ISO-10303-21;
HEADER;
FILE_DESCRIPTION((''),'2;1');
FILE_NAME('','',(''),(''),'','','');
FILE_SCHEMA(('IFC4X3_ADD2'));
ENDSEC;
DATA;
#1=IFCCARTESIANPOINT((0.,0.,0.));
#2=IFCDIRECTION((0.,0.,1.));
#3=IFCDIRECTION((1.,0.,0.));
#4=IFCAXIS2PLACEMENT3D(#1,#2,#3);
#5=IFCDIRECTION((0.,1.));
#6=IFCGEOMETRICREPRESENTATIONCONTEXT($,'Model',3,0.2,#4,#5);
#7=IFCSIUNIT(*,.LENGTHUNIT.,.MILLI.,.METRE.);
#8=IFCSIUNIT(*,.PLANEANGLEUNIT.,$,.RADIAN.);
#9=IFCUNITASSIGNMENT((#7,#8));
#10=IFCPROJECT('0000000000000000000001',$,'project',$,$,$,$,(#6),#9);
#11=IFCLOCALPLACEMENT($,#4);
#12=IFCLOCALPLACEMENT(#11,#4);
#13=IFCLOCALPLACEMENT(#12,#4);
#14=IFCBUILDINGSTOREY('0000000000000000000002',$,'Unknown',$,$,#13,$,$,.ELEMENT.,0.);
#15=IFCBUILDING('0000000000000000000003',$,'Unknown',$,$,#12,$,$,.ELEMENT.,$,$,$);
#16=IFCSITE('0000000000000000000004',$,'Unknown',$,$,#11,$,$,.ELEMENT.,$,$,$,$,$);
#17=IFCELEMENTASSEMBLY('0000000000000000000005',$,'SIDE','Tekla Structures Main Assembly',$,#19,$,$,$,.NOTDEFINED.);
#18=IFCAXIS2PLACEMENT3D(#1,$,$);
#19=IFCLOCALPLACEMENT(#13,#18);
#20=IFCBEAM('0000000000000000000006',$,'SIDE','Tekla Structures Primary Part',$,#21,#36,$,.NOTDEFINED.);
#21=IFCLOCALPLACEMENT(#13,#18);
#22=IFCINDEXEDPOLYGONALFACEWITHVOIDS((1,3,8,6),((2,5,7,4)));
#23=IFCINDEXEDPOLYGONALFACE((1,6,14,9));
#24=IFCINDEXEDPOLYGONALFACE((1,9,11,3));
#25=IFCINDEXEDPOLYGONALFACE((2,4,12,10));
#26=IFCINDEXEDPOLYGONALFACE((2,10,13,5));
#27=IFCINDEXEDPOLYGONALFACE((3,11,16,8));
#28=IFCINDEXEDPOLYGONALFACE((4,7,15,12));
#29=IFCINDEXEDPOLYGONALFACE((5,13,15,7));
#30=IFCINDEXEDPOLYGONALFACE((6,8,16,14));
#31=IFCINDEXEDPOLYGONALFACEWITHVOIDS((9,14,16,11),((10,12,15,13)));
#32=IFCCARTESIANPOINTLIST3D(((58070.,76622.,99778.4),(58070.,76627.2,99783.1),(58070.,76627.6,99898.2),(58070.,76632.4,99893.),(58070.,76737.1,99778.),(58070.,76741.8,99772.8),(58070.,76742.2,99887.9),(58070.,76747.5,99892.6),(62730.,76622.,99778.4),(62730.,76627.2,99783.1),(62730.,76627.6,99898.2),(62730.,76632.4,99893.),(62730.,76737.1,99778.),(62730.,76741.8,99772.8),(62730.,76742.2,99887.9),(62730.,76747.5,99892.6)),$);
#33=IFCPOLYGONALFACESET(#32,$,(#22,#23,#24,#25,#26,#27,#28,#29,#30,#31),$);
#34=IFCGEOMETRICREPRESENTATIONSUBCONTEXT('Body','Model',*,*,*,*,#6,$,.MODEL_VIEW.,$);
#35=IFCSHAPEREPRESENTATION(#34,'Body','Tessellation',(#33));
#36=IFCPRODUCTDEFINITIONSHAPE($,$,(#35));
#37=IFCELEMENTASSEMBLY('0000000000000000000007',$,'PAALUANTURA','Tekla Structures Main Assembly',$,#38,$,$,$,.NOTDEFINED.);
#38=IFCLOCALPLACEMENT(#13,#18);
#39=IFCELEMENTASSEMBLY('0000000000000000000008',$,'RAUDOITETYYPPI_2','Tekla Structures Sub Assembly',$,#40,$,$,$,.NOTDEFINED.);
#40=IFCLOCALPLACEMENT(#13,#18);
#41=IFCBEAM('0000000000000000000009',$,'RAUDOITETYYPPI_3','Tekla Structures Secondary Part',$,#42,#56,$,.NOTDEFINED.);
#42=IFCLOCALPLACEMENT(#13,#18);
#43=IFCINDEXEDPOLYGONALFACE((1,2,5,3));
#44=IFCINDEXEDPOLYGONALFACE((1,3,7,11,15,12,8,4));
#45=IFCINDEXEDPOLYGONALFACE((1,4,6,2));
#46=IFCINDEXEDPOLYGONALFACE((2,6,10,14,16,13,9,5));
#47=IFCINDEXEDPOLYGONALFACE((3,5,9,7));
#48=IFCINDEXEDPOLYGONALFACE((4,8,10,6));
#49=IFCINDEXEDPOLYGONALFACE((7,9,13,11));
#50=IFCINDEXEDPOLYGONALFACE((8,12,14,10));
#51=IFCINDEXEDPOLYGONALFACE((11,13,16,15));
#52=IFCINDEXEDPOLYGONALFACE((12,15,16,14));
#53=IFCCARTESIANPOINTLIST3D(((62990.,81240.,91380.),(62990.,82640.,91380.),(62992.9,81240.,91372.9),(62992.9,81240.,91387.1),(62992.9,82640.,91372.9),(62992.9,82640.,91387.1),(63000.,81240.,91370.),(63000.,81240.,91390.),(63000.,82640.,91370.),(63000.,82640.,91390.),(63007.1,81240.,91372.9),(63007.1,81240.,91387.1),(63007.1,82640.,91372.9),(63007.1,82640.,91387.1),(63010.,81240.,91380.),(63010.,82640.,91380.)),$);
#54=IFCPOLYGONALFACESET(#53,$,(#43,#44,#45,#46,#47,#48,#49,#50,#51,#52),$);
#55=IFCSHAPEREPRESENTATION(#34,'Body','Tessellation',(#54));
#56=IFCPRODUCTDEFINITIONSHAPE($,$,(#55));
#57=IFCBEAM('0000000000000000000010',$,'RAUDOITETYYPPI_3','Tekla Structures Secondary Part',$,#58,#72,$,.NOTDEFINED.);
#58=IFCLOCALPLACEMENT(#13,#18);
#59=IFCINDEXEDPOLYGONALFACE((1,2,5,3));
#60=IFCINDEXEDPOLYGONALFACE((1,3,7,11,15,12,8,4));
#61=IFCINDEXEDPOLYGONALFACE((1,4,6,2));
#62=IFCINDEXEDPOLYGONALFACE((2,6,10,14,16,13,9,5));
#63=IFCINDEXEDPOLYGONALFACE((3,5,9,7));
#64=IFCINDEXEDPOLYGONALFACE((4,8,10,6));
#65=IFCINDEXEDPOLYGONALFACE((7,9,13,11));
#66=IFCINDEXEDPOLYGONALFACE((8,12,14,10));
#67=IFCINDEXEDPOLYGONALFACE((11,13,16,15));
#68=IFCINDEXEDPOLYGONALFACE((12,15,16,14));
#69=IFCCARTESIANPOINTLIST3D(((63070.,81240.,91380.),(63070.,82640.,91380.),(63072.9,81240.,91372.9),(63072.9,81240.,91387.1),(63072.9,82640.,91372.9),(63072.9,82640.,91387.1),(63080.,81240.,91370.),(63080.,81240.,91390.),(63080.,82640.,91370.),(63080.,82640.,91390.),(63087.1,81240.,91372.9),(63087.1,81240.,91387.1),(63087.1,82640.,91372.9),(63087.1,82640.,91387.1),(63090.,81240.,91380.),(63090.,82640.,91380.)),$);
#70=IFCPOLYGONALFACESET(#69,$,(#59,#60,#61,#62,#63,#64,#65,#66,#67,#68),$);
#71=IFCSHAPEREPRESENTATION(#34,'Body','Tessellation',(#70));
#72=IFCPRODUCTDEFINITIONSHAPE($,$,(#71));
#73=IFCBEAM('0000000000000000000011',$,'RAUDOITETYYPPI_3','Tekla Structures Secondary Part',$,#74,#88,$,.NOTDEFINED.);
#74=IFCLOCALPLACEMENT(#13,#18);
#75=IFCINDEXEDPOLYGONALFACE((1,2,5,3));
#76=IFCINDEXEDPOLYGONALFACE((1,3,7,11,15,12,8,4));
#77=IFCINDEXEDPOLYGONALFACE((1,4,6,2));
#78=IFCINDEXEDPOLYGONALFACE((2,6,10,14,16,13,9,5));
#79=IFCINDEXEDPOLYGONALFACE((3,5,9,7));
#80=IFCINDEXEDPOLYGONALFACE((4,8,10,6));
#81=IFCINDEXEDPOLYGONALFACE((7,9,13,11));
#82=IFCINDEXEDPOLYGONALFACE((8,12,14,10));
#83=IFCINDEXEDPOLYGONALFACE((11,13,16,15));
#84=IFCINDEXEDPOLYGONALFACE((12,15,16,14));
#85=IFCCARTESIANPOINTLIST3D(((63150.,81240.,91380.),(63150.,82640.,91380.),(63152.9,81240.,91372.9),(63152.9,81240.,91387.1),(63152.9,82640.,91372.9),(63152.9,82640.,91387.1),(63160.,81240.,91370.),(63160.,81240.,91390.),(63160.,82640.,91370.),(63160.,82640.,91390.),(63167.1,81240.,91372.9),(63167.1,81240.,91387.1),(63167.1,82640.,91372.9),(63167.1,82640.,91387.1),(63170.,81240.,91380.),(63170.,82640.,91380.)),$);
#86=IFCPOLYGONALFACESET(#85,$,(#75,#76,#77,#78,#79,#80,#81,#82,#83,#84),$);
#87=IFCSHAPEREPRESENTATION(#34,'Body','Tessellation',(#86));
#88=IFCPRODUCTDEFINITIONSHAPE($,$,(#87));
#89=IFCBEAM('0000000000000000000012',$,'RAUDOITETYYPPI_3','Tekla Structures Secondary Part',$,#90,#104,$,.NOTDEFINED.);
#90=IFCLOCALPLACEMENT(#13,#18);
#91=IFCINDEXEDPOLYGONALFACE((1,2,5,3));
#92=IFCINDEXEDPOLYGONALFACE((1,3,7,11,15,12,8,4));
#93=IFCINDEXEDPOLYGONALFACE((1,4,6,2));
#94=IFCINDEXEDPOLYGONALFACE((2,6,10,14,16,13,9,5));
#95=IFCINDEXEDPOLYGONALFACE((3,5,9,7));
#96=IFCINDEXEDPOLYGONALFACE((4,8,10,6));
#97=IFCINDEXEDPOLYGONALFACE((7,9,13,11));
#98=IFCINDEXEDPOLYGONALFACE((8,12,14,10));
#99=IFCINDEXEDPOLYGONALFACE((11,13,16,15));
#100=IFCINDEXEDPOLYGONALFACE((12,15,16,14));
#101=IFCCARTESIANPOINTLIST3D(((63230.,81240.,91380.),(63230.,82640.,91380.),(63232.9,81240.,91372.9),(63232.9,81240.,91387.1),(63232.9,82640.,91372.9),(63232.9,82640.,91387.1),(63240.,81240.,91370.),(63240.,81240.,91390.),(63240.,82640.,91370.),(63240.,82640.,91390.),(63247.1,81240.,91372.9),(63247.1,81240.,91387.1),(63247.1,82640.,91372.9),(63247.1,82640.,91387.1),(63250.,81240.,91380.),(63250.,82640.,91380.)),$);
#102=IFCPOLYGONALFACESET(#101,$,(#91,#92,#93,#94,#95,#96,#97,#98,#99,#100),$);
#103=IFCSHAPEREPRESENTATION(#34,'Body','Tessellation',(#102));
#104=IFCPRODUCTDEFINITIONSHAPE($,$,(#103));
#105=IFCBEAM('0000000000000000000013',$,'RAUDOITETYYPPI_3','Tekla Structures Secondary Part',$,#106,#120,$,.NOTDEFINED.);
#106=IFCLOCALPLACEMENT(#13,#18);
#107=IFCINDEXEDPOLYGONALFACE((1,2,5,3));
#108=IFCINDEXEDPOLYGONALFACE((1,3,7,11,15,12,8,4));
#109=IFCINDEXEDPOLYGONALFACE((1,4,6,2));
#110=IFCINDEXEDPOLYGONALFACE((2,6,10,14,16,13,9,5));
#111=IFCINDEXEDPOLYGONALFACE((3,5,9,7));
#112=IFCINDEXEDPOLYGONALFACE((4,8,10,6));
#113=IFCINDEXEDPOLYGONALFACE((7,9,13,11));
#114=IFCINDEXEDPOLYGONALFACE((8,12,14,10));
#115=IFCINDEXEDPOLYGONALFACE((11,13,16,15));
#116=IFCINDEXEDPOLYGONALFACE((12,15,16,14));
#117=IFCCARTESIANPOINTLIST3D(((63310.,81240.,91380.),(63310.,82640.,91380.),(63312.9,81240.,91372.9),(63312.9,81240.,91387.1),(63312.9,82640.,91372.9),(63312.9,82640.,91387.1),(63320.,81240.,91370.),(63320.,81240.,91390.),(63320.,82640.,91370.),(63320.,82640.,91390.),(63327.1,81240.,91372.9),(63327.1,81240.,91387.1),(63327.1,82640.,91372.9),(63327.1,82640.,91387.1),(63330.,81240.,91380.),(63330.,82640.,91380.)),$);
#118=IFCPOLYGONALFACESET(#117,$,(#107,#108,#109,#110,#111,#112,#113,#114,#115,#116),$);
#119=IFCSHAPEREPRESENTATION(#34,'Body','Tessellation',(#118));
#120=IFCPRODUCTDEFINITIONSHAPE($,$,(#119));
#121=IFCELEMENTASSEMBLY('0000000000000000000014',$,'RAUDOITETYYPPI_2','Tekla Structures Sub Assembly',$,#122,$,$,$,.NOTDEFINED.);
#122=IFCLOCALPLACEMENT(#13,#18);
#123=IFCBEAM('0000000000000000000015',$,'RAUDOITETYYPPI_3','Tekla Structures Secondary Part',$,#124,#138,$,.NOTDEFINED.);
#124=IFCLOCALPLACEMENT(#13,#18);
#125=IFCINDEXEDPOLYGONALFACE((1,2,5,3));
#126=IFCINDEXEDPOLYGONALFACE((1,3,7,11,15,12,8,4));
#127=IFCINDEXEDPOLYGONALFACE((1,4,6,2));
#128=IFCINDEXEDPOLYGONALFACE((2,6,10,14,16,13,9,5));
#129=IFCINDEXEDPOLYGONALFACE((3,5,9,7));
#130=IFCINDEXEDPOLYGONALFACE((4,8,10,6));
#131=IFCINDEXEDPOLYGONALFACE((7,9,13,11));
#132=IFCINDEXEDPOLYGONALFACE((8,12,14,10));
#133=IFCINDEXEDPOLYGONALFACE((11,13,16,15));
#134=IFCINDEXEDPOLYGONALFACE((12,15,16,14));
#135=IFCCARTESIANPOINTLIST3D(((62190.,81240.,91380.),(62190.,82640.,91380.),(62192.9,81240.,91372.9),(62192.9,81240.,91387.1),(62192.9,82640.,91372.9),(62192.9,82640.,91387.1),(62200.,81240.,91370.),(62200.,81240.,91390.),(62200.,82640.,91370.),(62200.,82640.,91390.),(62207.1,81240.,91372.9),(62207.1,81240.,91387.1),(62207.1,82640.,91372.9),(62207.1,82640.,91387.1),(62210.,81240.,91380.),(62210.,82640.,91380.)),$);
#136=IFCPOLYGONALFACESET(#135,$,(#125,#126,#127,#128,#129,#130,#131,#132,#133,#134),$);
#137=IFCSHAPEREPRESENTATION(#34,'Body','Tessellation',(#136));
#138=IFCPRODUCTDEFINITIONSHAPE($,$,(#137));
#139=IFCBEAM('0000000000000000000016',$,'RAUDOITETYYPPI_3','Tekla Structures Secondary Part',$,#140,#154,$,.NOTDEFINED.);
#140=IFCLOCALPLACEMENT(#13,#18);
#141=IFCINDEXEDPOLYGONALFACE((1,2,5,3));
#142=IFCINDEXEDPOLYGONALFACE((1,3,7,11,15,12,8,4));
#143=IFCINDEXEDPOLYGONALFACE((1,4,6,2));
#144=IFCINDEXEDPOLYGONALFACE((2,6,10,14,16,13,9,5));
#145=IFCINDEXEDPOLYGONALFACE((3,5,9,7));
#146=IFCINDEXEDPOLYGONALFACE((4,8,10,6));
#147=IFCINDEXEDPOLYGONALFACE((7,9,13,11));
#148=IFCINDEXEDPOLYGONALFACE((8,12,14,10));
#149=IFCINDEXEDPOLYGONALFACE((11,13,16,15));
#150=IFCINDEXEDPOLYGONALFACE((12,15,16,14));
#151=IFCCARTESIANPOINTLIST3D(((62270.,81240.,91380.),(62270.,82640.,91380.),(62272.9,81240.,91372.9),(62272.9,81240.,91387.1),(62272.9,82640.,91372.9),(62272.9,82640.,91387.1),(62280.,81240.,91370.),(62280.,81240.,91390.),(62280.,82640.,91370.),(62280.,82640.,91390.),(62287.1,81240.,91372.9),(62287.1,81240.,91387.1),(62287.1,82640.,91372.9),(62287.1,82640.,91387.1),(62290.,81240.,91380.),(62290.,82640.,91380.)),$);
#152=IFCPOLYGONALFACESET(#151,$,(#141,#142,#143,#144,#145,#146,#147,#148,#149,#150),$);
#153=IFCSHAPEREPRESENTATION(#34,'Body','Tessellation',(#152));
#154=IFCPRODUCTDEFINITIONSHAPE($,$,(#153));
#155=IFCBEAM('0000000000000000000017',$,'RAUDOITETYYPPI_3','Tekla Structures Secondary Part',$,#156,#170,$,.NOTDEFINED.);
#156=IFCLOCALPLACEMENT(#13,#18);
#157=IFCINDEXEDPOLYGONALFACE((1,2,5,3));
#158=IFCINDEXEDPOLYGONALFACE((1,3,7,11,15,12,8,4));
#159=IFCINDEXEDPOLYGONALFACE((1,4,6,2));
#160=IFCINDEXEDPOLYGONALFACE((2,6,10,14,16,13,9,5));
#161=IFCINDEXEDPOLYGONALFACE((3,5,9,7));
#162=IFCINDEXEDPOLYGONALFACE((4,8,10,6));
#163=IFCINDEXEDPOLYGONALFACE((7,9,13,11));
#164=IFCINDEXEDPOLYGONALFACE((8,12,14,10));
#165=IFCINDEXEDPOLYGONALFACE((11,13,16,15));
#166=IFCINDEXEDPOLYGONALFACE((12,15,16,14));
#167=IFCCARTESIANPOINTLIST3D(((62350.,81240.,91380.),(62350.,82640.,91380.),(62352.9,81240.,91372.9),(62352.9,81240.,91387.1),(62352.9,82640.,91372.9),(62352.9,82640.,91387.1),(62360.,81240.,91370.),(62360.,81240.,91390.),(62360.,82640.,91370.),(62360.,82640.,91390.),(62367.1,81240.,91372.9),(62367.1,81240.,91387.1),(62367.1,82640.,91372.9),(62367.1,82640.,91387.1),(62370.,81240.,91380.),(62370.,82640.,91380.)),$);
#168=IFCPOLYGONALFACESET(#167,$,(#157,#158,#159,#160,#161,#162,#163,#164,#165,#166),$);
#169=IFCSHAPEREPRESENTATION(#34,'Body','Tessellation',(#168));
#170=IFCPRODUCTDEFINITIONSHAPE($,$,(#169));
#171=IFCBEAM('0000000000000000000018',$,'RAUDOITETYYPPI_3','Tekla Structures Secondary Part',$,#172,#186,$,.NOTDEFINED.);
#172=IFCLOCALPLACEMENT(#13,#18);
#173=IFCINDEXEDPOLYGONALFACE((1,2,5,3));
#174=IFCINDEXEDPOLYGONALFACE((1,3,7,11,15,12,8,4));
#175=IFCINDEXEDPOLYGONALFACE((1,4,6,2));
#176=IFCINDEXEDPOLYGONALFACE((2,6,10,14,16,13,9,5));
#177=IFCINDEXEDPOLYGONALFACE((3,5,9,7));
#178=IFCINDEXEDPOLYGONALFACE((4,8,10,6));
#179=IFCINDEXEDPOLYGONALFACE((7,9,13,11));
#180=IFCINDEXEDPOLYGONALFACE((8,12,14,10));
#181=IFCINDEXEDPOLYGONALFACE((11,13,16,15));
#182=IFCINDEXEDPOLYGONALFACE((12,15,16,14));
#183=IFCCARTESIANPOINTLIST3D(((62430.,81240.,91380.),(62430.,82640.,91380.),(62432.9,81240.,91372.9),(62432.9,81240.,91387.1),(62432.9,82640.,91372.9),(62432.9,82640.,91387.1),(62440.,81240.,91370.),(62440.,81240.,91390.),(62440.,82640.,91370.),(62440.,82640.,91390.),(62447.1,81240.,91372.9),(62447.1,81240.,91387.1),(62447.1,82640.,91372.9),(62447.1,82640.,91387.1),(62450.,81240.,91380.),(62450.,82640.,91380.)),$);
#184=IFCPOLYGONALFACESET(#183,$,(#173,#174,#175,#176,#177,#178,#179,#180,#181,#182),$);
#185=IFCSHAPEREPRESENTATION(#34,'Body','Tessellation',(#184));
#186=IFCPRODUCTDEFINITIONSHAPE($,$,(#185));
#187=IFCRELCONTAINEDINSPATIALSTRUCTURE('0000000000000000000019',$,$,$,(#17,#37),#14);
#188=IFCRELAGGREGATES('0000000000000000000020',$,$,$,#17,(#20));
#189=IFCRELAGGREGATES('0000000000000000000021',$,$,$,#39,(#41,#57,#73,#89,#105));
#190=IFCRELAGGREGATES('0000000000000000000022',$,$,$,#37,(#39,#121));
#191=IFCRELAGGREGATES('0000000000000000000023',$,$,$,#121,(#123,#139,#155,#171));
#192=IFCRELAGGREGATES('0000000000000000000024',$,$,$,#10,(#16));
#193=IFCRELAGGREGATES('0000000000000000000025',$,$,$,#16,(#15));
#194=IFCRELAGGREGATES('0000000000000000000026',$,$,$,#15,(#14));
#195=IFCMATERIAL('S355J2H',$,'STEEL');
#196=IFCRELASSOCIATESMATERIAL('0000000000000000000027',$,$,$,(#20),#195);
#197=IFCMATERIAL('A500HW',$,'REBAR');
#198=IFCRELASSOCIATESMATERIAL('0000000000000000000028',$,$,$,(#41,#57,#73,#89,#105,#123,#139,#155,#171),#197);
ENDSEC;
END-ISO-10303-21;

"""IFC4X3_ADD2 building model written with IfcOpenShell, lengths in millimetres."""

from ifc_helpers import new_model, si_unit, direction, frame, origin_with_axes, place, context, subcontext, project, spatial, line, indexed_curve, outline, extrude, material, element, aggregate, save


model = new_model("IFC4X3_ADD2")

# Units and contexts
model_context = context("Model", 3, precision=0.2, world=origin_with_axes(), true_north=direction((0.0, 1.0)))
body_context = subcontext(model_context, "Body", "Model", "MODEL_VIEW")
ifc_project = project(units=[si_unit("LENGTHUNIT", "METRE", prefix="MILLI"), si_unit("PLANEANGLEUNIT", "RADIAN")], contexts=[model_context])

# Site, building, storey
site_placement = place(None, origin_with_axes())
site = spatial("IfcSite", under=ifc_project, at=site_placement, Name="Unknown", CompositionType="ELEMENT")
building_placement = place(site_placement, origin_with_axes())
building = spatial("IfcBuilding", under=site, at=building_placement, Name="Unknown", CompositionType="ELEMENT")
storey_placement = place(building_placement, origin_with_axes())
storey = spatial("IfcBuildingStorey", under=building, at=storey_placement, Name="Unknown", CompositionType="ELEMENT", Elevation=0.0)

# Element assembly, beam
ifc_material_1 = material(Name="S355J2H", Category="STEEL")
assembly_1_placement = place(storey_placement, frame((62730.0, 76684.7, 99835.5), z_axis=(0.0, 0.9989, -0.046897), x_axis=(-1.0, 0.0, 0.0)))
assembly_1 = element("IfcElementAssembly", 1, at=assembly_1_placement, inside=storey, Name="SIDE", Description="Tekla Structures Main Assembly", PredefinedType="NOTDEFINED")
beam_1_placement = place(assembly_1_placement, origin_with_axes())
beam_1 = element("IfcBeam", 2, at=beam_1_placement, material=ifc_material_1, Name="SIDE", Description="Tekla Structures Primary Part", PredefinedType="NOTDEFINED", context=body_context, shape_type="SolidModel", body=[
    extrude(outline(indexed_curve([(-60.0, -60.0), (60.0, -60.0), (60.0, 60.0), (-60.0, 60.0)], segments=[line(1, 2, 3, 4, 1)]), holes=[indexed_curve([(-55.0, -55.0), (-55.0, 55.0), (55.0, 55.0), (55.0, -55.0)], segments=[line(1, 2, 3, 4, 1)])]), frame((0.0, 0.0, 0.0), z_axis=(-1.0, 0.0, 0.0), x_axis=(0.0, 0.0, 1.0)), (0.0, 0.0, -1.0), 4660.0),
])
aggregate(assembly_1, [beam_1])

# Element assemblies, beams
assembly_2_placement = place(storey_placement, frame((62800.0, 81940.0, 92100.0), z_axis=(0.0, -1.0, 0.0), x_axis=(0.0, 0.0, -1.0)))
assembly_2 = element("IfcElementAssembly", 3, at=assembly_2_placement, inside=storey, Name="PAALUANTURA", Description="Tekla Structures Main Assembly", PredefinedType="NOTDEFINED")
assembly_3_placement = place(assembly_2_placement, frame((720.0, 600.0, 700.0), z_axis=(0.0, -1.0, 0.0), x_axis=(0.0, 0.0, -1.0)))
assembly_3 = element("IfcElementAssembly", 4, at=assembly_3_placement, Name="RAUDOITETYYPPI_2", Description="Tekla Structures Sub Assembly", PredefinedType="NOTDEFINED")
ifc_material_2 = material(Name="A500HW", Category="REBAR")
beam_2_placement = place(assembly_3_placement, frame((0.0, 0.0, 400.0), z_axis=(0.0, 0.0, 1.0), x_axis=(1.0, 0.0, 0.0)))
beam_2 = element("IfcBeam", 5, at=beam_2_placement, material=ifc_material_2, Name="RAUDOITETYYPPI_3", Description="Tekla Structures Secondary Part", PredefinedType="NOTDEFINED", context=body_context, shape_type="SolidModel", body=[
    extrude(outline(indexed_curve([(10.0, 0.0), (7.1, 7.1), (0.0, 10.0), (-7.1, 7.1), (-10.0, 0.0), (-7.1, -7.1), (0.0, -10.0), (7.1, -7.1)], segments=[line(1, 2, 3, 4, 5, 6, 7, 8, 1)])), frame((0.0, 0.0, 0.0), z_axis=(-1.0, 0.0, 0.0), x_axis=(0.0, 0.0, 1.0)), (0.0, 0.0, -1.0), 1400.0),
])
beam_3_placement = place(assembly_3_placement, frame((0.0, 0.0, 320.0), z_axis=(0.0, 0.0, 1.0), x_axis=(1.0, 0.0, 0.0)))
beam_3 = element("IfcBeam", 6, at=beam_3_placement, material=ifc_material_2, Name="RAUDOITETYYPPI_3", Description="Tekla Structures Secondary Part", PredefinedType="NOTDEFINED", context=body_context, shape_type="SolidModel", body=[
    extrude(outline(indexed_curve([(10.0, 0.0), (7.1, 7.1), (0.0, 10.0), (-7.1, 7.1), (-10.0, 0.0), (-7.1, -7.1), (0.0, -10.0), (7.1, -7.1)], segments=[line(1, 2, 3, 4, 5, 6, 7, 8, 1)])), frame((0.0, 0.0, 0.0), z_axis=(-1.0, 0.0, 0.0), x_axis=(0.0, 0.0, 1.0)), (0.0, 0.0, -1.0), 1400.0),
])
beam_4_placement = place(assembly_3_placement, frame((0.0, 0.0, 240.0), z_axis=(0.0, 0.0, 1.0), x_axis=(1.0, 0.0, 0.0)))
beam_4 = element("IfcBeam", 7, at=beam_4_placement, material=ifc_material_2, Name="RAUDOITETYYPPI_3", Description="Tekla Structures Secondary Part", PredefinedType="NOTDEFINED", context=body_context, shape_type="SolidModel", body=[
    extrude(outline(indexed_curve([(10.0, 0.0), (7.1, 7.1), (0.0, 10.0), (-7.1, 7.1), (-10.0, 0.0), (-7.1, -7.1), (0.0, -10.0), (7.1, -7.1)], segments=[line(1, 2, 3, 4, 5, 6, 7, 8, 1)])), frame((0.0, 0.0, 0.0), z_axis=(-1.0, 0.0, 0.0), x_axis=(0.0, 0.0, 1.0)), (0.0, 0.0, -1.0), 1400.0),
])
beam_5_placement = place(assembly_3_placement, frame((0.0, 0.0, 160.0), z_axis=(0.0, 0.0, 1.0), x_axis=(1.0, 0.0, 0.0)))
beam_5 = element("IfcBeam", 8, at=beam_5_placement, material=ifc_material_2, Name="RAUDOITETYYPPI_3", Description="Tekla Structures Secondary Part", PredefinedType="NOTDEFINED", context=body_context, shape_type="SolidModel", body=[
    extrude(outline(indexed_curve([(10.0, 0.0), (7.1, 7.1), (0.0, 10.0), (-7.1, 7.1), (-10.0, 0.0), (-7.1, -7.1), (0.0, -10.0), (7.1, -7.1)], segments=[line(1, 2, 3, 4, 5, 6, 7, 8, 1)])), frame((0.0, 0.0, 0.0), z_axis=(-1.0, 0.0, 0.0), x_axis=(0.0, 0.0, 1.0)), (0.0, 0.0, -1.0), 1400.0),
])
beam_6_placement = place(assembly_3_placement, frame((0.0, 0.0, 80.0), z_axis=(0.0, 0.0, 1.0), x_axis=(1.0, 0.0, 0.0)))
beam_6 = element("IfcBeam", 9, at=beam_6_placement, material=ifc_material_2, Name="RAUDOITETYYPPI_3", Description="Tekla Structures Secondary Part", PredefinedType="NOTDEFINED", context=body_context, shape_type="SolidModel", body=[
    extrude(outline(indexed_curve([(10.0, 0.0), (7.1, 7.1), (0.0, 10.0), (-7.1, 7.1), (-10.0, 0.0), (-7.1, -7.1), (0.0, -10.0), (7.1, -7.1)], segments=[line(1, 2, 3, 4, 5, 6, 7, 8, 1)])), frame((0.0, 0.0, 0.0), z_axis=(-1.0, 0.0, 0.0), x_axis=(0.0, 0.0, 1.0)), (0.0, 0.0, -1.0), 1400.0),
])
aggregate(assembly_3, [beam_2, beam_3, beam_4, beam_5, beam_6])
assembly_4_placement = place(assembly_2_placement, frame((720.0, -200.0, 700.0), z_axis=(0.0, -1.0, 0.0), x_axis=(0.0, 0.0, -1.0)))
assembly_4 = element("IfcElementAssembly", 10, at=assembly_4_placement, Name="RAUDOITETYYPPI_2", Description="Tekla Structures Sub Assembly", PredefinedType="NOTDEFINED")
aggregate(assembly_2, [assembly_3, assembly_4])
beam_7_placement = place(assembly_4_placement, frame((0.0, 0.0, 400.0), z_axis=(0.0, 0.0, 1.0), x_axis=(1.0, 0.0, 0.0)))
beam_7 = element("IfcBeam", 11, at=beam_7_placement, material=ifc_material_2, Name="RAUDOITETYYPPI_3", Description="Tekla Structures Secondary Part", PredefinedType="NOTDEFINED", context=body_context, shape_type="SolidModel", body=[
    extrude(outline(indexed_curve([(10.0, 0.0), (7.1, 7.1), (0.0, 10.0), (-7.1, 7.1), (-10.0, 0.0), (-7.1, -7.1), (0.0, -10.0), (7.1, -7.1)], segments=[line(1, 2, 3, 4, 5, 6, 7, 8, 1)])), frame((0.0, 0.0, 0.0), z_axis=(-1.0, 0.0, 0.0), x_axis=(0.0, 0.0, 1.0)), (0.0, 0.0, -1.0), 1400.0),
])
beam_8_placement = place(assembly_4_placement, frame((0.0, 0.0, 320.0), z_axis=(0.0, 0.0, 1.0), x_axis=(1.0, 0.0, 0.0)))
beam_8 = element("IfcBeam", 12, at=beam_8_placement, material=ifc_material_2, Name="RAUDOITETYYPPI_3", Description="Tekla Structures Secondary Part", PredefinedType="NOTDEFINED", context=body_context, shape_type="SolidModel", body=[
    extrude(outline(indexed_curve([(10.0, 0.0), (7.1, 7.1), (0.0, 10.0), (-7.1, 7.1), (-10.0, 0.0), (-7.1, -7.1), (0.0, -10.0), (7.1, -7.1)], segments=[line(1, 2, 3, 4, 5, 6, 7, 8, 1)])), frame((0.0, 0.0, 0.0), z_axis=(-1.0, 0.0, 0.0), x_axis=(0.0, 0.0, 1.0)), (0.0, 0.0, -1.0), 1400.0),
])
beam_9_placement = place(assembly_4_placement, frame((0.0, 0.0, 240.0), z_axis=(0.0, 0.0, 1.0), x_axis=(1.0, 0.0, 0.0)))
beam_9 = element("IfcBeam", 13, at=beam_9_placement, material=ifc_material_2, Name="RAUDOITETYYPPI_3", Description="Tekla Structures Secondary Part", PredefinedType="NOTDEFINED", context=body_context, shape_type="SolidModel", body=[
    extrude(outline(indexed_curve([(10.0, 0.0), (7.1, 7.1), (0.0, 10.0), (-7.1, 7.1), (-10.0, 0.0), (-7.1, -7.1), (0.0, -10.0), (7.1, -7.1)], segments=[line(1, 2, 3, 4, 5, 6, 7, 8, 1)])), frame((0.0, 0.0, 0.0), z_axis=(-1.0, 0.0, 0.0), x_axis=(0.0, 0.0, 1.0)), (0.0, 0.0, -1.0), 1400.0),
])
beam_10_placement = place(assembly_4_placement, frame((0.0, 0.0, 160.0), z_axis=(0.0, 0.0, 1.0), x_axis=(1.0, 0.0, 0.0)))
beam_10 = element("IfcBeam", 14, at=beam_10_placement, material=ifc_material_2, Name="RAUDOITETYYPPI_3", Description="Tekla Structures Secondary Part", PredefinedType="NOTDEFINED", context=body_context, shape_type="SolidModel", body=[
    extrude(outline(indexed_curve([(10.0, 0.0), (7.1, 7.1), (0.0, 10.0), (-7.1, 7.1), (-10.0, 0.0), (-7.1, -7.1), (0.0, -10.0), (7.1, -7.1)], segments=[line(1, 2, 3, 4, 5, 6, 7, 8, 1)])), frame((0.0, 0.0, 0.0), z_axis=(-1.0, 0.0, 0.0), x_axis=(0.0, 0.0, 1.0)), (0.0, 0.0, -1.0), 1400.0),
])
aggregate(assembly_4, [beam_7, beam_8, beam_9, beam_10])

save(model, "model.ifc")
